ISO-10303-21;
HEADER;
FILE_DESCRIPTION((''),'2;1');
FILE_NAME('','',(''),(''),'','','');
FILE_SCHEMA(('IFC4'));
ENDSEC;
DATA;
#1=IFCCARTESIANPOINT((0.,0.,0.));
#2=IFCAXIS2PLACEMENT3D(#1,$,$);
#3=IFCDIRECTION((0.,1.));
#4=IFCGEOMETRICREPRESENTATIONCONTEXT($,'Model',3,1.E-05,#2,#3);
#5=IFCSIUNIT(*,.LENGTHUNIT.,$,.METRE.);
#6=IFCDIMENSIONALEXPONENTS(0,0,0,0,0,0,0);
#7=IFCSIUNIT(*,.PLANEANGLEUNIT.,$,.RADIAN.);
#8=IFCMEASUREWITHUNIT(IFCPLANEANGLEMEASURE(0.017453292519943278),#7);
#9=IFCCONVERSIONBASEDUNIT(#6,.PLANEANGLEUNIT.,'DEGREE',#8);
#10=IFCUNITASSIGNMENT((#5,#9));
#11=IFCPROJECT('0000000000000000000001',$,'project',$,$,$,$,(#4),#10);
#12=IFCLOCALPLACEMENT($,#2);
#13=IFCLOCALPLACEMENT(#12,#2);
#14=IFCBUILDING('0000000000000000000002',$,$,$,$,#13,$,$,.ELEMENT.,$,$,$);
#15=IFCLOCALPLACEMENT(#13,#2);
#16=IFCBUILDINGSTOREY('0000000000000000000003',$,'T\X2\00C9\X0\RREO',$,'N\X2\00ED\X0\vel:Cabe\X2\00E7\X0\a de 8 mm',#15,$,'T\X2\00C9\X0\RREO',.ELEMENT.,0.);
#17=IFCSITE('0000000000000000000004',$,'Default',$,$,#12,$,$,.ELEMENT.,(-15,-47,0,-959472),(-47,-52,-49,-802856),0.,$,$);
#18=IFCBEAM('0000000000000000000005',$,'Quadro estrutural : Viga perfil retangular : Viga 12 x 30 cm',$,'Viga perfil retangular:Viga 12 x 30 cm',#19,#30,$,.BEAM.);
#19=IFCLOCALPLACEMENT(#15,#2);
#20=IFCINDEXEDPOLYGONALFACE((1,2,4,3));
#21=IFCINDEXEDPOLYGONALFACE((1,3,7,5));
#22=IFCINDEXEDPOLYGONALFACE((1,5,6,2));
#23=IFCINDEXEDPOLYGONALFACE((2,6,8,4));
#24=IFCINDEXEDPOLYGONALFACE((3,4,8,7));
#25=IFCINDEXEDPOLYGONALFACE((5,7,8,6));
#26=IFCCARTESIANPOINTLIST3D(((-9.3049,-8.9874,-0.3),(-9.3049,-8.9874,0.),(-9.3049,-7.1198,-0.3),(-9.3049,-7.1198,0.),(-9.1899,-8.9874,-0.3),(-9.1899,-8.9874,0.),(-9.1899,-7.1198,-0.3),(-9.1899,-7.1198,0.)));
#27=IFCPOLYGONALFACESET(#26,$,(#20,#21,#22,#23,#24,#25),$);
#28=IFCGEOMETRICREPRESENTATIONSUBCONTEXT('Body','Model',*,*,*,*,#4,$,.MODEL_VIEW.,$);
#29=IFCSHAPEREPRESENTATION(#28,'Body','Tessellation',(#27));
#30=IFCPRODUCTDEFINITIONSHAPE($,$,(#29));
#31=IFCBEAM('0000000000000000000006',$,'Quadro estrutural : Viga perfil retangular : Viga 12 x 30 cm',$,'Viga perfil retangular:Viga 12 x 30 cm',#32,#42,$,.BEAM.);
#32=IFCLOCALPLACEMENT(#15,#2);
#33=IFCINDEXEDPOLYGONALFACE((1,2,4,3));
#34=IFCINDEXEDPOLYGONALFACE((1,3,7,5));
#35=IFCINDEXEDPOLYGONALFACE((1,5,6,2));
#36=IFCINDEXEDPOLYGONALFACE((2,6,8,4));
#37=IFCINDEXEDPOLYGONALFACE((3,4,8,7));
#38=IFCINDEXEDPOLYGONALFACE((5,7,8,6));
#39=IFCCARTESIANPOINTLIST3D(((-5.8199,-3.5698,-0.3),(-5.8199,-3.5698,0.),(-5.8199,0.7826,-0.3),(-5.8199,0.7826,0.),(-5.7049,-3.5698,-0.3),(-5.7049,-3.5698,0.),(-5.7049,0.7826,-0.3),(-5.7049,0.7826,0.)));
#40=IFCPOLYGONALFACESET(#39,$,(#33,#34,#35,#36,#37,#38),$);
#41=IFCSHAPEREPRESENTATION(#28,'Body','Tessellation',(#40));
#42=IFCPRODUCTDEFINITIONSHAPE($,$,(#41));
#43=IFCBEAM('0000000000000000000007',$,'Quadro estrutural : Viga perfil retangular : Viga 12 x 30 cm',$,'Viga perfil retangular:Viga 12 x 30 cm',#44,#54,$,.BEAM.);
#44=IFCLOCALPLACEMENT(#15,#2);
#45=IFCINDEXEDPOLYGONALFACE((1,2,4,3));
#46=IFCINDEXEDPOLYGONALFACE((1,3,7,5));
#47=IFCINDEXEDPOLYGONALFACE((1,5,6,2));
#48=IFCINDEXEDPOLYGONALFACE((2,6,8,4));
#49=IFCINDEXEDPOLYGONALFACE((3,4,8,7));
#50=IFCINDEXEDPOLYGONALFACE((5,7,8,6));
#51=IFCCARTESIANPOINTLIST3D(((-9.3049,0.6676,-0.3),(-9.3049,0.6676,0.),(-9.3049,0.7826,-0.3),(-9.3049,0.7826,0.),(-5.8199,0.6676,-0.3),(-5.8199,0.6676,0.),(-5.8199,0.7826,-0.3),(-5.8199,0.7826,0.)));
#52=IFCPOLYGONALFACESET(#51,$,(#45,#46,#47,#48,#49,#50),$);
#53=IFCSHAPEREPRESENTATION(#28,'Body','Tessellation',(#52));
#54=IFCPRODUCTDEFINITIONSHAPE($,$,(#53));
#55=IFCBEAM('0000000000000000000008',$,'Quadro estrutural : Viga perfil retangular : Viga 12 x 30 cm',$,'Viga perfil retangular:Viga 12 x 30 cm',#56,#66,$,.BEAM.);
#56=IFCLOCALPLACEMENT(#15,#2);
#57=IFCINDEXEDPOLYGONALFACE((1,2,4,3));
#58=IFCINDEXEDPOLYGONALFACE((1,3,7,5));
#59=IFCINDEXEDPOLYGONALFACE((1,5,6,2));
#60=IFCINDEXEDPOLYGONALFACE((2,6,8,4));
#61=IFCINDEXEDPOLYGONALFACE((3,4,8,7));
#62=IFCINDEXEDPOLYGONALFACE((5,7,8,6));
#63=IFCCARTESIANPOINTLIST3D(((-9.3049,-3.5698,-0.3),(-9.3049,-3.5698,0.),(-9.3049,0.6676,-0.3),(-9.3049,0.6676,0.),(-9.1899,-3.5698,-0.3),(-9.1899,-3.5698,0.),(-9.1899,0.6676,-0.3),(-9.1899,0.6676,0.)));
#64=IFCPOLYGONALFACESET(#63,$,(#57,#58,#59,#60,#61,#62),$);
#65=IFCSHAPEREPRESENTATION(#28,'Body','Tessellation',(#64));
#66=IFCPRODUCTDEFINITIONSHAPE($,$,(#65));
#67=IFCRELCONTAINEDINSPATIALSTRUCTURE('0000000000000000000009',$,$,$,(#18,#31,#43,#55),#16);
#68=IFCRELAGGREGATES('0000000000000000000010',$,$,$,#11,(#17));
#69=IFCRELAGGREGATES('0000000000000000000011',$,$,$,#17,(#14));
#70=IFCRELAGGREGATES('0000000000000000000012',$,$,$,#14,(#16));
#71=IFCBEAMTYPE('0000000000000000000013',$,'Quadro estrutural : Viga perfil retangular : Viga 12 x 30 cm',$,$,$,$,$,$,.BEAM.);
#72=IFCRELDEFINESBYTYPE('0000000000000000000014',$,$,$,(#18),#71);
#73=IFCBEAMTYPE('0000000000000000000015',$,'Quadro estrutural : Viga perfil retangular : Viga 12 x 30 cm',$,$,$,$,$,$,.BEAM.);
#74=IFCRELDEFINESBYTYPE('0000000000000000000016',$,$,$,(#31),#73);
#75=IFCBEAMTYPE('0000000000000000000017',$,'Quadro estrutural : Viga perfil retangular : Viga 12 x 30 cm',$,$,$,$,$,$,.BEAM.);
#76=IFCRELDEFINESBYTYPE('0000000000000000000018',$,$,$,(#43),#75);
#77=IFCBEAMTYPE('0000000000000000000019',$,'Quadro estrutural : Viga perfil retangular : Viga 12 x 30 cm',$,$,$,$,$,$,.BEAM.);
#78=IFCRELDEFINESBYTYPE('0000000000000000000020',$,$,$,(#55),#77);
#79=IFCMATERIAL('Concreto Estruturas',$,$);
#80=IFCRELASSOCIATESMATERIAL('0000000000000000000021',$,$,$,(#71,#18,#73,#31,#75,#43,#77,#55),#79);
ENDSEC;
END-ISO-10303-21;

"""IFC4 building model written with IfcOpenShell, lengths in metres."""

from ifc_helpers import new_model, entity, si_unit, converted_unit, direction, frame, origin, place, context, subcontext, project, spatial, indexed_curve, outline, extrude, source, transform, mapped, material, type_object, type_shapes, element, save


model = new_model("IFC4")

# Units and contexts
model_context = context("Model", 3, precision=1e-05, world=origin(), true_north=direction((0.0, 1.0)))
body_context = subcontext(model_context, "Body", "Model", "MODEL_VIEW")
ifc_project = project(units=[si_unit("LENGTHUNIT", "METRE"), converted_unit("PLANEANGLEUNIT", "DEGREE", entity("IfcPlaneAngleMeasure", 0.017453292519943278), si_unit("PLANEANGLEUNIT", "RADIAN"), dimensions=[0, 0, 0, 0, 0, 0, 0])], contexts=[model_context])

# Site, building, storey
site_placement = place(None, origin())
site = spatial("IfcSite", under=ifc_project, at=site_placement, Name="Default", CompositionType="ELEMENT", RefLatitude=(-15, -47, 0, -959472), RefLongitude=(-47, -52, -49, -802856), RefElevation=0.0)
building_placement = place(site_placement, origin())
building = spatial("IfcBuilding", under=site, at=building_placement, CompositionType="ELEMENT")
storey_placement = place(building_placement, origin())
storey = spatial("IfcBuildingStorey", under=building, at=storey_placement, Name="TÉRREO", ObjectType="Nível:Cabeça de 8 mm", LongName="TÉRREO", CompositionType="ELEMENT", Elevation=0.0)

# Beams
ifc_material_1 = material(Name="Concreto Estruturas")
beam_type_1 = type_object("IfcBeamType", Name="Quadro estrutural : Viga perfil retangular : Viga 12 x 30 cm", PredefinedType="BEAM", material=ifc_material_1)
shared_shape_1 = source(origin(), body_context, "Body", "SweptSolid", [
    extrude(outline(indexed_curve([(-0.0575, -0.15), (0.0575, -0.15), (0.0575, 0.15), (-0.0575, 0.15), (-0.0575, -0.15)], self_intersect=False)), frame((-9.2474, -7.1198, -0.15), z_axis=(0.0, -1.0, 0.0), x_axis=(-1.0, 0.0, 0.0)), (0.0, 0.0, 1.0), 1.8676),
])
type_shapes(beam_type_1, [shared_shape_1])
beam_1_placement = place(storey_placement, origin())
element("IfcBeam", 1, at=beam_1_placement, inside=storey, type_object=beam_type_1, material=ifc_material_1, Name="Quadro estrutural : Viga perfil retangular : Viga 12 x 30 cm", ObjectType="Viga perfil retangular:Viga 12 x 30 cm", PredefinedType="BEAM", context=body_context, shape_type="MappedRepresentation", body=[
    mapped(shared_shape_1, transform((0.0, 0.0, 0.0), scale=1.0)),
])
beam_type_2 = type_object("IfcBeamType", Name="Quadro estrutural : Viga perfil retangular : Viga 12 x 30 cm", PredefinedType="BEAM", material=ifc_material_1)
shared_shape_2 = source(origin(), body_context, "Body", "SweptSolid", [
    extrude(outline(indexed_curve([(-0.0575, -0.15), (0.0575, -0.15), (0.0575, 0.15), (-0.0575, 0.15), (-0.0575, -0.15)], self_intersect=False)), frame((-5.7624, -3.5698, -0.15), z_axis=(0.0, 1.0, 0.0), x_axis=(-1.0, 0.0, 0.0)), (0.0, 0.0, 1.0), 4.3524),
])
type_shapes(beam_type_2, [shared_shape_2])
beam_2_placement = place(storey_placement, origin())
element("IfcBeam", 2, at=beam_2_placement, inside=storey, type_object=beam_type_2, material=ifc_material_1, Name="Quadro estrutural : Viga perfil retangular : Viga 12 x 30 cm", ObjectType="Viga perfil retangular:Viga 12 x 30 cm", PredefinedType="BEAM", context=body_context, shape_type="MappedRepresentation", body=[
    mapped(shared_shape_2, transform((0.0, 0.0, 0.0), scale=1.0)),
])
beam_type_3 = type_object("IfcBeamType", Name="Quadro estrutural : Viga perfil retangular : Viga 12 x 30 cm", PredefinedType="BEAM", material=ifc_material_1)
shared_shape_3 = source(origin(), body_context, "Body", "SweptSolid", [
    extrude(outline(indexed_curve([(-0.15, -0.0575), (0.15, -0.0575), (0.15, 0.0575), (-0.15, 0.0575), (-0.15, -0.0575)], self_intersect=False)), frame((-5.8199, 0.7251, -0.15), z_axis=(-1.0, 0.0, 0.0), x_axis=(0.0, 0.0, -1.0)), (0.0, 0.0, 1.0), 3.485),
])
type_shapes(beam_type_3, [shared_shape_3])
beam_3_placement = place(storey_placement, origin())
element("IfcBeam", 3, at=beam_3_placement, inside=storey, type_object=beam_type_3, material=ifc_material_1, Name="Quadro estrutural : Viga perfil retangular : Viga 12 x 30 cm", ObjectType="Viga perfil retangular:Viga 12 x 30 cm", PredefinedType="BEAM", context=body_context, shape_type="MappedRepresentation", body=[
    mapped(shared_shape_3, transform((0.0, 0.0, 0.0), scale=1.0)),
])
beam_type_4 = type_object("IfcBeamType", Name="Quadro estrutural : Viga perfil retangular : Viga 12 x 30 cm", PredefinedType="BEAM", material=ifc_material_1)
shared_shape_4 = source(origin(), body_context, "Body", "SweptSolid", [
    extrude(outline(indexed_curve([(-0.0575, -0.15), (0.0575, -0.15), (0.0575, 0.15), (-0.0575, 0.15), (-0.0575, -0.15)], self_intersect=False)), frame((-9.2474, 0.6676, -0.15), z_axis=(0.0, -1.0, 0.0), x_axis=(-1.0, 0.0, 0.0)), (0.0, 0.0, 1.0), 4.2374),
])
type_shapes(beam_type_4, [shared_shape_4])
beam_4_placement = place(storey_placement, origin())
element("IfcBeam", 4, at=beam_4_placement, inside=storey, type_object=beam_type_4, material=ifc_material_1, Name="Quadro estrutural : Viga perfil retangular : Viga 12 x 30 cm", ObjectType="Viga perfil retangular:Viga 12 x 30 cm", PredefinedType="BEAM", context=body_context, shape_type="MappedRepresentation", body=[
    mapped(shared_shape_4, transform((0.0, 0.0, 0.0), scale=1.0)),
])

save(model, "model.ifc")
